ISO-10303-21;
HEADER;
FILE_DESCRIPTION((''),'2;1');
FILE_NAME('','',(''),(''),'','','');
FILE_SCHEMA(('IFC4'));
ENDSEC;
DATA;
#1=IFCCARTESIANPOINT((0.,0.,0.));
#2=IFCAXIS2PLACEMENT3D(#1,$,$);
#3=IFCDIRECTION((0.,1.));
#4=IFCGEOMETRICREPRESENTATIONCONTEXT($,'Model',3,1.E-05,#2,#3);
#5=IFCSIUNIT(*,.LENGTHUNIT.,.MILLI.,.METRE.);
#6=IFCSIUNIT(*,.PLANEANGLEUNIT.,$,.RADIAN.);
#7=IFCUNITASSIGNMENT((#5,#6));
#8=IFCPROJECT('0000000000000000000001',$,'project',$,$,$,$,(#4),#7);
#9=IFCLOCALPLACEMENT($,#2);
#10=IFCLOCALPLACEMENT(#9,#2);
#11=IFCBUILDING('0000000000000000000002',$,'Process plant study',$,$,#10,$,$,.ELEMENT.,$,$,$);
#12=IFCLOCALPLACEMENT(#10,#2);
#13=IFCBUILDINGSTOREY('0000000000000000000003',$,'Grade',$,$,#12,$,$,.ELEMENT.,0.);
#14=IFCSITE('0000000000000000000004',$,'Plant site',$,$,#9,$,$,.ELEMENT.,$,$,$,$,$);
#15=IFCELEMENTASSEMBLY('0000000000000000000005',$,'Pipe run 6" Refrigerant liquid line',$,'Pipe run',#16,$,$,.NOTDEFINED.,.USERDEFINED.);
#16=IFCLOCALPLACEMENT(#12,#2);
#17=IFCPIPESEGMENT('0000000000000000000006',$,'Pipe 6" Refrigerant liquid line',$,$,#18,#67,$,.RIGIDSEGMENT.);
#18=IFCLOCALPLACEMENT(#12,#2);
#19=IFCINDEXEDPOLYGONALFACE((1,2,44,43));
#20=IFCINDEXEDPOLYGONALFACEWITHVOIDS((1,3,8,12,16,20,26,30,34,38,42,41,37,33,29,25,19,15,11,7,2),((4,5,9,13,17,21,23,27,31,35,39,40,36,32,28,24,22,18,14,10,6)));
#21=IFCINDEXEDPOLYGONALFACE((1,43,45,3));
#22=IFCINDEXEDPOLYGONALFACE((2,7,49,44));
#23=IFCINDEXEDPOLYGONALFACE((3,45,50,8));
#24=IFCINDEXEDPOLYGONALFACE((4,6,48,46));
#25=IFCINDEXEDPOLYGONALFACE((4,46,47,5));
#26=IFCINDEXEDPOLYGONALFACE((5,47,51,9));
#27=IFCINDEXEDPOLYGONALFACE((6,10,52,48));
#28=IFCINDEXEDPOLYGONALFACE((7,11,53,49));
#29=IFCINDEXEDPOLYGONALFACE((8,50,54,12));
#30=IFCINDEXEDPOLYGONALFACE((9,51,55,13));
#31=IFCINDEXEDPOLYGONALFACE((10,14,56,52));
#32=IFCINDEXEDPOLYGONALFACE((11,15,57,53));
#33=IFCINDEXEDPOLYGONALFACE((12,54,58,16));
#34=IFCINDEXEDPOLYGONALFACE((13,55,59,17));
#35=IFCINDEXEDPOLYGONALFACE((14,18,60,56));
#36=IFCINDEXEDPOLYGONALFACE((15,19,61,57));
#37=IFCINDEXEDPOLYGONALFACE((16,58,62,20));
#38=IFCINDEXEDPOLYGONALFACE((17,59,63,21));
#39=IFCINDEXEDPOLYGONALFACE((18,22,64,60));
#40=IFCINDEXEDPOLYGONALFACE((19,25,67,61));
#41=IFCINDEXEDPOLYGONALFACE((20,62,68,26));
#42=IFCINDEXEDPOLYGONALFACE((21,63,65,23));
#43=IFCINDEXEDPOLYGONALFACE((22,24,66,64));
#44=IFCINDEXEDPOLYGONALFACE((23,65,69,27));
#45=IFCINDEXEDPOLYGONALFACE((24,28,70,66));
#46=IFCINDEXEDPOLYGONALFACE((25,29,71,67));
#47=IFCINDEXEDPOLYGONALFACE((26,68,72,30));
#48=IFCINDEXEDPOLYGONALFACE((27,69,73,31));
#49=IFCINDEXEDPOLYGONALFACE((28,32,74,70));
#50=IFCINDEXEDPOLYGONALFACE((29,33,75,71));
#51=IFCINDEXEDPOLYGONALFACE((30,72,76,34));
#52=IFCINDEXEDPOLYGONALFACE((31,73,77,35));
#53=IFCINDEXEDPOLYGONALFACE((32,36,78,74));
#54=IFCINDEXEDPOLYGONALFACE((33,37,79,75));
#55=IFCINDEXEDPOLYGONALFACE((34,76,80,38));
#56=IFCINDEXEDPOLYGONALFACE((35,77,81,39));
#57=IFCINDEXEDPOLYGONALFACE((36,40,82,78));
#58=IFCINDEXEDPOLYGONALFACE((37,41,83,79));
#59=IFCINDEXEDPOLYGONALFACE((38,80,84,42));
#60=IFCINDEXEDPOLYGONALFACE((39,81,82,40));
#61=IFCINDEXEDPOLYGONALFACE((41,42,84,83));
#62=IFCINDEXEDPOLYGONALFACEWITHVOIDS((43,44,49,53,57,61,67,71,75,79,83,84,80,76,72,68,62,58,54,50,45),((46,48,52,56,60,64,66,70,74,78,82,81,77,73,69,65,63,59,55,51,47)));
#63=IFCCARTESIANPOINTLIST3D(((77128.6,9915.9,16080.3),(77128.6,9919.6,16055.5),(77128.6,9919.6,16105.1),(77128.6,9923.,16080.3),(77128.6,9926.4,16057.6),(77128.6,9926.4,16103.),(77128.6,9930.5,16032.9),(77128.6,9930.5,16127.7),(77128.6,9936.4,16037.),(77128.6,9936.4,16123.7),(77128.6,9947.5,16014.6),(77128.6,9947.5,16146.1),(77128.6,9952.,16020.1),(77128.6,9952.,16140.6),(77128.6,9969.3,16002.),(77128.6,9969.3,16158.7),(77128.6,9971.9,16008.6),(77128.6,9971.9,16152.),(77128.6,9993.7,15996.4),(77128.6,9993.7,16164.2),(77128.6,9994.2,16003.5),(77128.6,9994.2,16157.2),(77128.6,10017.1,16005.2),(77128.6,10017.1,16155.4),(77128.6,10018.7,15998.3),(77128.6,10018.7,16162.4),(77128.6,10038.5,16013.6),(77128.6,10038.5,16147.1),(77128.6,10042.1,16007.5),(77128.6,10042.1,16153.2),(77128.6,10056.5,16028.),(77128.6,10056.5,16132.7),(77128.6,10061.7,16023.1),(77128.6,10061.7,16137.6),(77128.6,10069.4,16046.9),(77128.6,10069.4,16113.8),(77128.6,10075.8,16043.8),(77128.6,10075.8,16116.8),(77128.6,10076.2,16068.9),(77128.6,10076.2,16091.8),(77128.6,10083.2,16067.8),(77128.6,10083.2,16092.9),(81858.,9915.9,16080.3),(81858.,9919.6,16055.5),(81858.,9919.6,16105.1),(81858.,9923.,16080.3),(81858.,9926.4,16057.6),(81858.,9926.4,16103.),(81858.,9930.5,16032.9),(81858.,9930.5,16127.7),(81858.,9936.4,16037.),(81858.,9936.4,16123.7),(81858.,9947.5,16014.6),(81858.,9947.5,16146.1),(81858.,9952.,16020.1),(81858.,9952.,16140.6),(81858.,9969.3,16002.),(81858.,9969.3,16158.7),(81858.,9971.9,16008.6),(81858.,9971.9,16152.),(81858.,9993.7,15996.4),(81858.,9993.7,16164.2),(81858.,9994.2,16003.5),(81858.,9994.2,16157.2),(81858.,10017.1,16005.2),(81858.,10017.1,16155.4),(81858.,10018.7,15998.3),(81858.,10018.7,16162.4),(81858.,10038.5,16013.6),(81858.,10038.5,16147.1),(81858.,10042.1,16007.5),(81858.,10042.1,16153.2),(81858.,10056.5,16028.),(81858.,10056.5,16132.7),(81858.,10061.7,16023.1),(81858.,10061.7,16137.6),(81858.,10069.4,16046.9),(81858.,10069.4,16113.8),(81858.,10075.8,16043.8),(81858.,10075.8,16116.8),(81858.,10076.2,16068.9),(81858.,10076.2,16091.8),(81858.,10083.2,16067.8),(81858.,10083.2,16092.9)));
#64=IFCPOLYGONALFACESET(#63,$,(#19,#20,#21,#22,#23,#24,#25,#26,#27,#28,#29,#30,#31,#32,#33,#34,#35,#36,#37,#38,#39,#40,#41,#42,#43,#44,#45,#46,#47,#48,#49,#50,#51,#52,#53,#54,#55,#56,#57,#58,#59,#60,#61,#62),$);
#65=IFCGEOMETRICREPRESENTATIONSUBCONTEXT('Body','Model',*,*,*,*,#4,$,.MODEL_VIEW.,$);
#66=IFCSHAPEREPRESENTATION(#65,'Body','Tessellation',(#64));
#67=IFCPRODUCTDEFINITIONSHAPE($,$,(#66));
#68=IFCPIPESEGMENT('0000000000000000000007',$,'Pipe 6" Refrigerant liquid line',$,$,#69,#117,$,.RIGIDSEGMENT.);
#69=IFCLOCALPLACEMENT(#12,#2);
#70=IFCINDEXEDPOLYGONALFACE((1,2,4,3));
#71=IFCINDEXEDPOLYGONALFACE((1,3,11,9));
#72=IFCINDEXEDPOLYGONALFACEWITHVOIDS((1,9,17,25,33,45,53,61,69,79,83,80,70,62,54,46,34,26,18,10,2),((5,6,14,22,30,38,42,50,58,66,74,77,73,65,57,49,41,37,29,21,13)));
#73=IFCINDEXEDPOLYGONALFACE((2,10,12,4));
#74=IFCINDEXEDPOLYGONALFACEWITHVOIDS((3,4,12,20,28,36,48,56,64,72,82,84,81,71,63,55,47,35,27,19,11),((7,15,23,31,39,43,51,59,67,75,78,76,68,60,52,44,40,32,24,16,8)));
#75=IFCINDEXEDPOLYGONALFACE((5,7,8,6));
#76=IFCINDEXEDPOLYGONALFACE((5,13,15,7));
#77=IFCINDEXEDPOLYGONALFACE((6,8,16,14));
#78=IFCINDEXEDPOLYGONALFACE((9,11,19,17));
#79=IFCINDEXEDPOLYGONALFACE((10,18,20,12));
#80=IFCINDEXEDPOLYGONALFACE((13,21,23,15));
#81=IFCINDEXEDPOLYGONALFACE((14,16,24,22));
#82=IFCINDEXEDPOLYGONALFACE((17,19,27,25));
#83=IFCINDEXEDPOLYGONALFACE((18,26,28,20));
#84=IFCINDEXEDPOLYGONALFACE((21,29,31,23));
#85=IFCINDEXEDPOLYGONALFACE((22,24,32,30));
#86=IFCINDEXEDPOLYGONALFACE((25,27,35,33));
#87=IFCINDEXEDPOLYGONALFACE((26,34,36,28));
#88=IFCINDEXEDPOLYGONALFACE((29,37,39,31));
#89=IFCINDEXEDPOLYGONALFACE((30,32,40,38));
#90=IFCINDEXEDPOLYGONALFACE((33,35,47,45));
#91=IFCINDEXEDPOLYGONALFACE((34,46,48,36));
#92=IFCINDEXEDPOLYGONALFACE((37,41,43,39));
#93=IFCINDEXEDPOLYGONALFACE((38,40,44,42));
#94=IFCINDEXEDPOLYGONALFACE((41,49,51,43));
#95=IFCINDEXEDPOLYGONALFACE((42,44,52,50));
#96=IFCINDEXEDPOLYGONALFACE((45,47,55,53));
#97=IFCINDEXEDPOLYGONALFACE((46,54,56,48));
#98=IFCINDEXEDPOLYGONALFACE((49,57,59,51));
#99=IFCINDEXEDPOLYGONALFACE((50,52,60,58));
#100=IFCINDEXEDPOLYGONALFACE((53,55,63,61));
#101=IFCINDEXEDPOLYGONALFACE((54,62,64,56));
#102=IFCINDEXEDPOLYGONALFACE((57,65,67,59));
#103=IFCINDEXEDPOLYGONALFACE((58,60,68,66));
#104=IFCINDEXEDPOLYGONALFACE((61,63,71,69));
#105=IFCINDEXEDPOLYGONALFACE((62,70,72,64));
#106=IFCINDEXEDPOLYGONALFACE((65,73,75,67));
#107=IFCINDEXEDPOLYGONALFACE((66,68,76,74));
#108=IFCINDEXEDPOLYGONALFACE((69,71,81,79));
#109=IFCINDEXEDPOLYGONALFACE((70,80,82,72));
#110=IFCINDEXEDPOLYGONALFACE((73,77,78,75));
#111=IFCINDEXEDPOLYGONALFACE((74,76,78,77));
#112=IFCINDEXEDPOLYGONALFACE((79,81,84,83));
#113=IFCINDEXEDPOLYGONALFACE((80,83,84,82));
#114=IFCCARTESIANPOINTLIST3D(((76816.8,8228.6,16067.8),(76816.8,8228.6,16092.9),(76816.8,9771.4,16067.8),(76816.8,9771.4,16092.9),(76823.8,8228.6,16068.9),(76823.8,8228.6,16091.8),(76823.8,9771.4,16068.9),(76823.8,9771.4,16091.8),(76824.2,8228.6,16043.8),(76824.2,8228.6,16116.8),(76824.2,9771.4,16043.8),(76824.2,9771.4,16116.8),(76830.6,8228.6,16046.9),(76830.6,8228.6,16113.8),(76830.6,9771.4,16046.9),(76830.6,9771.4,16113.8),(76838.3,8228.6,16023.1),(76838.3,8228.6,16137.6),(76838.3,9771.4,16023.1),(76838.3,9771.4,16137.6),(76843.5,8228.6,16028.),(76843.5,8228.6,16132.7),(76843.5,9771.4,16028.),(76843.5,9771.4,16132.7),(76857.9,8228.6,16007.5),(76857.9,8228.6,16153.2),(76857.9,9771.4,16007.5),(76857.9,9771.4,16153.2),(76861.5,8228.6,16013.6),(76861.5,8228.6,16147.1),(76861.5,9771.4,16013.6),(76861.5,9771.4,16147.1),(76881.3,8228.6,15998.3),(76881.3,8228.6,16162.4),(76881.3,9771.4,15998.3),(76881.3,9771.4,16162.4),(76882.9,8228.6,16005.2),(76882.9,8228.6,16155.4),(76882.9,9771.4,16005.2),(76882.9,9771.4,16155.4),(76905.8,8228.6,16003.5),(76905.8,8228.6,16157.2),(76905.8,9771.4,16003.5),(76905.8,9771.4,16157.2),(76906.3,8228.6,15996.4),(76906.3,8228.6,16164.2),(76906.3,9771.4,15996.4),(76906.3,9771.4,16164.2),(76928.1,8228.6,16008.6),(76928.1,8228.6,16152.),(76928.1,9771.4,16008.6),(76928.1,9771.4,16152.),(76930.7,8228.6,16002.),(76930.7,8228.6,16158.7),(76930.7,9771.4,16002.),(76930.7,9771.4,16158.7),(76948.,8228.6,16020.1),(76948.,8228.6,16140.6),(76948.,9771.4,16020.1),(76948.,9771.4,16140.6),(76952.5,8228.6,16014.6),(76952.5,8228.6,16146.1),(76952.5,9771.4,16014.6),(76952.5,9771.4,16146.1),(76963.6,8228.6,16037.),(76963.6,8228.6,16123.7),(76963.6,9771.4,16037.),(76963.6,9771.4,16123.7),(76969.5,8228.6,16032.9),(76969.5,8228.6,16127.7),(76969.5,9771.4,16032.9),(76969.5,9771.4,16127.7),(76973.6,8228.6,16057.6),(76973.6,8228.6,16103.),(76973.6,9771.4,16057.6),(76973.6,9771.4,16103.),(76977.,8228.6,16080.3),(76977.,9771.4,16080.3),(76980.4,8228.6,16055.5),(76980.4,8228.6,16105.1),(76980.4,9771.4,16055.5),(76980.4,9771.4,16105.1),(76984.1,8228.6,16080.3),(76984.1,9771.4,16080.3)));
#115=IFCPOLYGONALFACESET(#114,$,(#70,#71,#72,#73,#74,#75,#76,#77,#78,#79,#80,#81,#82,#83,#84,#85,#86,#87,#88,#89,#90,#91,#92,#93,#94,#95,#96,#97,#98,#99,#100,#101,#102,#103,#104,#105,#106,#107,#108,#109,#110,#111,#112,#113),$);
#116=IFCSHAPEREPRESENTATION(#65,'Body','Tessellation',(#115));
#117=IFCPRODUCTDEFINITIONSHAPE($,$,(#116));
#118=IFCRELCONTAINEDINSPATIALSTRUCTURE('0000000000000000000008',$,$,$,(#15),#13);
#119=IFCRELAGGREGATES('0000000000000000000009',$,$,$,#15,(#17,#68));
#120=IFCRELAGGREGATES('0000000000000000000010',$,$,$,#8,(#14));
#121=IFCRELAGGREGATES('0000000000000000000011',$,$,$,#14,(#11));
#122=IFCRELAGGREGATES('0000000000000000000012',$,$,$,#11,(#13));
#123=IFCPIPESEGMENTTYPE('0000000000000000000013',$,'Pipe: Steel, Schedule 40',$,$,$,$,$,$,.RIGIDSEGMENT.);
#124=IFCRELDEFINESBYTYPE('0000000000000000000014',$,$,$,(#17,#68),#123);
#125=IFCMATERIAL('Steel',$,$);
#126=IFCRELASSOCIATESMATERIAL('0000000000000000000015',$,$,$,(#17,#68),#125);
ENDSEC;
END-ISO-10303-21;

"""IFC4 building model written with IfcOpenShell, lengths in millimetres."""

from ifc_helpers import new_model, si_unit, direction, frame, origin, origin_with_axes, origin_2d, place, context, subcontext, project, spatial, hollow_circle, extrude, material, type_object, element, aggregate, save


model = new_model("IFC4")

# Units and contexts
model_context = context("Model", 3, precision=1e-05, world=origin(), true_north=direction((0.0, 1.0)))
body_context = subcontext(model_context, "Body", "Model", "MODEL_VIEW")
ifc_project = project(units=[si_unit("LENGTHUNIT", "METRE", prefix="MILLI"), si_unit("PLANEANGLEUNIT", "RADIAN")], contexts=[model_context])

# Site, building, storey
site_placement = place(None, origin())
site = spatial("IfcSite", under=ifc_project, at=site_placement, Name="Plant site", CompositionType="ELEMENT")
building_placement = place(site_placement, origin())
building = spatial("IfcBuilding", under=site, at=building_placement, Name="Process plant study", CompositionType="ELEMENT")
storey_placement = place(building_placement, origin())
storey = spatial("IfcBuildingStorey", under=building, at=storey_placement, Name="Grade", CompositionType="ELEMENT", Elevation=0.0)

# Element assembly, pipe segments
ifc_material = material(Name="Steel")
pipe_segment_type = type_object("IfcPipeSegmentType", Name="Pipe: Steel, Schedule 40", PredefinedType="RIGIDSEGMENT")
assembly_1_placement = place(storey_placement, origin_with_axes())
assembly_1 = element("IfcElementAssembly", 1, at=assembly_1_placement, inside=storey, Name="Pipe run 6\" Refrigerant liquid line", ObjectType="Pipe run", AssemblyPlace="NOTDEFINED", PredefinedType="USERDEFINED")
pipe_segment_1_placement = place(storey_placement, origin_with_axes())
pipe_segment_1 = element("IfcPipeSegment", 2, at=pipe_segment_1_placement, type_object=pipe_segment_type, material=ifc_material, Name="Pipe 6\" Refrigerant liquid line", PredefinedType="RIGIDSEGMENT", context=body_context, shape_type="SweptSolid", body=[
    extrude(hollow_circle(Radius=84.1, WallThickness=7.1, at=origin_2d()), frame((81857.9, 10000.0, 16080.3), z_axis=(-1.0, 0.0, 0.0), x_axis=(0.0, -1.0, 0.0)), (0.0, 0.0, 1.0), 4729.4),
])
pipe_segment_2_placement = place(storey_placement, origin_with_axes())
pipe_segment_2 = element("IfcPipeSegment", 3, at=pipe_segment_2_placement, type_object=pipe_segment_type, material=ifc_material, Name="Pipe 6\" Refrigerant liquid line", PredefinedType="RIGIDSEGMENT", context=body_context, shape_type="SweptSolid", body=[
    extrude(hollow_circle(Radius=84.1, WallThickness=7.1, at=origin_2d()), frame((76900.0, 9771.4, 16080.3), z_axis=(0.0, -1.0, 0.0), x_axis=(1.0, 0.0, 0.0)), (0.0, 0.0, 1.0), 1542.8),
])

aggregate(assembly_1, [pipe_segment_1, pipe_segment_2])

save(model, "model.ifc")
